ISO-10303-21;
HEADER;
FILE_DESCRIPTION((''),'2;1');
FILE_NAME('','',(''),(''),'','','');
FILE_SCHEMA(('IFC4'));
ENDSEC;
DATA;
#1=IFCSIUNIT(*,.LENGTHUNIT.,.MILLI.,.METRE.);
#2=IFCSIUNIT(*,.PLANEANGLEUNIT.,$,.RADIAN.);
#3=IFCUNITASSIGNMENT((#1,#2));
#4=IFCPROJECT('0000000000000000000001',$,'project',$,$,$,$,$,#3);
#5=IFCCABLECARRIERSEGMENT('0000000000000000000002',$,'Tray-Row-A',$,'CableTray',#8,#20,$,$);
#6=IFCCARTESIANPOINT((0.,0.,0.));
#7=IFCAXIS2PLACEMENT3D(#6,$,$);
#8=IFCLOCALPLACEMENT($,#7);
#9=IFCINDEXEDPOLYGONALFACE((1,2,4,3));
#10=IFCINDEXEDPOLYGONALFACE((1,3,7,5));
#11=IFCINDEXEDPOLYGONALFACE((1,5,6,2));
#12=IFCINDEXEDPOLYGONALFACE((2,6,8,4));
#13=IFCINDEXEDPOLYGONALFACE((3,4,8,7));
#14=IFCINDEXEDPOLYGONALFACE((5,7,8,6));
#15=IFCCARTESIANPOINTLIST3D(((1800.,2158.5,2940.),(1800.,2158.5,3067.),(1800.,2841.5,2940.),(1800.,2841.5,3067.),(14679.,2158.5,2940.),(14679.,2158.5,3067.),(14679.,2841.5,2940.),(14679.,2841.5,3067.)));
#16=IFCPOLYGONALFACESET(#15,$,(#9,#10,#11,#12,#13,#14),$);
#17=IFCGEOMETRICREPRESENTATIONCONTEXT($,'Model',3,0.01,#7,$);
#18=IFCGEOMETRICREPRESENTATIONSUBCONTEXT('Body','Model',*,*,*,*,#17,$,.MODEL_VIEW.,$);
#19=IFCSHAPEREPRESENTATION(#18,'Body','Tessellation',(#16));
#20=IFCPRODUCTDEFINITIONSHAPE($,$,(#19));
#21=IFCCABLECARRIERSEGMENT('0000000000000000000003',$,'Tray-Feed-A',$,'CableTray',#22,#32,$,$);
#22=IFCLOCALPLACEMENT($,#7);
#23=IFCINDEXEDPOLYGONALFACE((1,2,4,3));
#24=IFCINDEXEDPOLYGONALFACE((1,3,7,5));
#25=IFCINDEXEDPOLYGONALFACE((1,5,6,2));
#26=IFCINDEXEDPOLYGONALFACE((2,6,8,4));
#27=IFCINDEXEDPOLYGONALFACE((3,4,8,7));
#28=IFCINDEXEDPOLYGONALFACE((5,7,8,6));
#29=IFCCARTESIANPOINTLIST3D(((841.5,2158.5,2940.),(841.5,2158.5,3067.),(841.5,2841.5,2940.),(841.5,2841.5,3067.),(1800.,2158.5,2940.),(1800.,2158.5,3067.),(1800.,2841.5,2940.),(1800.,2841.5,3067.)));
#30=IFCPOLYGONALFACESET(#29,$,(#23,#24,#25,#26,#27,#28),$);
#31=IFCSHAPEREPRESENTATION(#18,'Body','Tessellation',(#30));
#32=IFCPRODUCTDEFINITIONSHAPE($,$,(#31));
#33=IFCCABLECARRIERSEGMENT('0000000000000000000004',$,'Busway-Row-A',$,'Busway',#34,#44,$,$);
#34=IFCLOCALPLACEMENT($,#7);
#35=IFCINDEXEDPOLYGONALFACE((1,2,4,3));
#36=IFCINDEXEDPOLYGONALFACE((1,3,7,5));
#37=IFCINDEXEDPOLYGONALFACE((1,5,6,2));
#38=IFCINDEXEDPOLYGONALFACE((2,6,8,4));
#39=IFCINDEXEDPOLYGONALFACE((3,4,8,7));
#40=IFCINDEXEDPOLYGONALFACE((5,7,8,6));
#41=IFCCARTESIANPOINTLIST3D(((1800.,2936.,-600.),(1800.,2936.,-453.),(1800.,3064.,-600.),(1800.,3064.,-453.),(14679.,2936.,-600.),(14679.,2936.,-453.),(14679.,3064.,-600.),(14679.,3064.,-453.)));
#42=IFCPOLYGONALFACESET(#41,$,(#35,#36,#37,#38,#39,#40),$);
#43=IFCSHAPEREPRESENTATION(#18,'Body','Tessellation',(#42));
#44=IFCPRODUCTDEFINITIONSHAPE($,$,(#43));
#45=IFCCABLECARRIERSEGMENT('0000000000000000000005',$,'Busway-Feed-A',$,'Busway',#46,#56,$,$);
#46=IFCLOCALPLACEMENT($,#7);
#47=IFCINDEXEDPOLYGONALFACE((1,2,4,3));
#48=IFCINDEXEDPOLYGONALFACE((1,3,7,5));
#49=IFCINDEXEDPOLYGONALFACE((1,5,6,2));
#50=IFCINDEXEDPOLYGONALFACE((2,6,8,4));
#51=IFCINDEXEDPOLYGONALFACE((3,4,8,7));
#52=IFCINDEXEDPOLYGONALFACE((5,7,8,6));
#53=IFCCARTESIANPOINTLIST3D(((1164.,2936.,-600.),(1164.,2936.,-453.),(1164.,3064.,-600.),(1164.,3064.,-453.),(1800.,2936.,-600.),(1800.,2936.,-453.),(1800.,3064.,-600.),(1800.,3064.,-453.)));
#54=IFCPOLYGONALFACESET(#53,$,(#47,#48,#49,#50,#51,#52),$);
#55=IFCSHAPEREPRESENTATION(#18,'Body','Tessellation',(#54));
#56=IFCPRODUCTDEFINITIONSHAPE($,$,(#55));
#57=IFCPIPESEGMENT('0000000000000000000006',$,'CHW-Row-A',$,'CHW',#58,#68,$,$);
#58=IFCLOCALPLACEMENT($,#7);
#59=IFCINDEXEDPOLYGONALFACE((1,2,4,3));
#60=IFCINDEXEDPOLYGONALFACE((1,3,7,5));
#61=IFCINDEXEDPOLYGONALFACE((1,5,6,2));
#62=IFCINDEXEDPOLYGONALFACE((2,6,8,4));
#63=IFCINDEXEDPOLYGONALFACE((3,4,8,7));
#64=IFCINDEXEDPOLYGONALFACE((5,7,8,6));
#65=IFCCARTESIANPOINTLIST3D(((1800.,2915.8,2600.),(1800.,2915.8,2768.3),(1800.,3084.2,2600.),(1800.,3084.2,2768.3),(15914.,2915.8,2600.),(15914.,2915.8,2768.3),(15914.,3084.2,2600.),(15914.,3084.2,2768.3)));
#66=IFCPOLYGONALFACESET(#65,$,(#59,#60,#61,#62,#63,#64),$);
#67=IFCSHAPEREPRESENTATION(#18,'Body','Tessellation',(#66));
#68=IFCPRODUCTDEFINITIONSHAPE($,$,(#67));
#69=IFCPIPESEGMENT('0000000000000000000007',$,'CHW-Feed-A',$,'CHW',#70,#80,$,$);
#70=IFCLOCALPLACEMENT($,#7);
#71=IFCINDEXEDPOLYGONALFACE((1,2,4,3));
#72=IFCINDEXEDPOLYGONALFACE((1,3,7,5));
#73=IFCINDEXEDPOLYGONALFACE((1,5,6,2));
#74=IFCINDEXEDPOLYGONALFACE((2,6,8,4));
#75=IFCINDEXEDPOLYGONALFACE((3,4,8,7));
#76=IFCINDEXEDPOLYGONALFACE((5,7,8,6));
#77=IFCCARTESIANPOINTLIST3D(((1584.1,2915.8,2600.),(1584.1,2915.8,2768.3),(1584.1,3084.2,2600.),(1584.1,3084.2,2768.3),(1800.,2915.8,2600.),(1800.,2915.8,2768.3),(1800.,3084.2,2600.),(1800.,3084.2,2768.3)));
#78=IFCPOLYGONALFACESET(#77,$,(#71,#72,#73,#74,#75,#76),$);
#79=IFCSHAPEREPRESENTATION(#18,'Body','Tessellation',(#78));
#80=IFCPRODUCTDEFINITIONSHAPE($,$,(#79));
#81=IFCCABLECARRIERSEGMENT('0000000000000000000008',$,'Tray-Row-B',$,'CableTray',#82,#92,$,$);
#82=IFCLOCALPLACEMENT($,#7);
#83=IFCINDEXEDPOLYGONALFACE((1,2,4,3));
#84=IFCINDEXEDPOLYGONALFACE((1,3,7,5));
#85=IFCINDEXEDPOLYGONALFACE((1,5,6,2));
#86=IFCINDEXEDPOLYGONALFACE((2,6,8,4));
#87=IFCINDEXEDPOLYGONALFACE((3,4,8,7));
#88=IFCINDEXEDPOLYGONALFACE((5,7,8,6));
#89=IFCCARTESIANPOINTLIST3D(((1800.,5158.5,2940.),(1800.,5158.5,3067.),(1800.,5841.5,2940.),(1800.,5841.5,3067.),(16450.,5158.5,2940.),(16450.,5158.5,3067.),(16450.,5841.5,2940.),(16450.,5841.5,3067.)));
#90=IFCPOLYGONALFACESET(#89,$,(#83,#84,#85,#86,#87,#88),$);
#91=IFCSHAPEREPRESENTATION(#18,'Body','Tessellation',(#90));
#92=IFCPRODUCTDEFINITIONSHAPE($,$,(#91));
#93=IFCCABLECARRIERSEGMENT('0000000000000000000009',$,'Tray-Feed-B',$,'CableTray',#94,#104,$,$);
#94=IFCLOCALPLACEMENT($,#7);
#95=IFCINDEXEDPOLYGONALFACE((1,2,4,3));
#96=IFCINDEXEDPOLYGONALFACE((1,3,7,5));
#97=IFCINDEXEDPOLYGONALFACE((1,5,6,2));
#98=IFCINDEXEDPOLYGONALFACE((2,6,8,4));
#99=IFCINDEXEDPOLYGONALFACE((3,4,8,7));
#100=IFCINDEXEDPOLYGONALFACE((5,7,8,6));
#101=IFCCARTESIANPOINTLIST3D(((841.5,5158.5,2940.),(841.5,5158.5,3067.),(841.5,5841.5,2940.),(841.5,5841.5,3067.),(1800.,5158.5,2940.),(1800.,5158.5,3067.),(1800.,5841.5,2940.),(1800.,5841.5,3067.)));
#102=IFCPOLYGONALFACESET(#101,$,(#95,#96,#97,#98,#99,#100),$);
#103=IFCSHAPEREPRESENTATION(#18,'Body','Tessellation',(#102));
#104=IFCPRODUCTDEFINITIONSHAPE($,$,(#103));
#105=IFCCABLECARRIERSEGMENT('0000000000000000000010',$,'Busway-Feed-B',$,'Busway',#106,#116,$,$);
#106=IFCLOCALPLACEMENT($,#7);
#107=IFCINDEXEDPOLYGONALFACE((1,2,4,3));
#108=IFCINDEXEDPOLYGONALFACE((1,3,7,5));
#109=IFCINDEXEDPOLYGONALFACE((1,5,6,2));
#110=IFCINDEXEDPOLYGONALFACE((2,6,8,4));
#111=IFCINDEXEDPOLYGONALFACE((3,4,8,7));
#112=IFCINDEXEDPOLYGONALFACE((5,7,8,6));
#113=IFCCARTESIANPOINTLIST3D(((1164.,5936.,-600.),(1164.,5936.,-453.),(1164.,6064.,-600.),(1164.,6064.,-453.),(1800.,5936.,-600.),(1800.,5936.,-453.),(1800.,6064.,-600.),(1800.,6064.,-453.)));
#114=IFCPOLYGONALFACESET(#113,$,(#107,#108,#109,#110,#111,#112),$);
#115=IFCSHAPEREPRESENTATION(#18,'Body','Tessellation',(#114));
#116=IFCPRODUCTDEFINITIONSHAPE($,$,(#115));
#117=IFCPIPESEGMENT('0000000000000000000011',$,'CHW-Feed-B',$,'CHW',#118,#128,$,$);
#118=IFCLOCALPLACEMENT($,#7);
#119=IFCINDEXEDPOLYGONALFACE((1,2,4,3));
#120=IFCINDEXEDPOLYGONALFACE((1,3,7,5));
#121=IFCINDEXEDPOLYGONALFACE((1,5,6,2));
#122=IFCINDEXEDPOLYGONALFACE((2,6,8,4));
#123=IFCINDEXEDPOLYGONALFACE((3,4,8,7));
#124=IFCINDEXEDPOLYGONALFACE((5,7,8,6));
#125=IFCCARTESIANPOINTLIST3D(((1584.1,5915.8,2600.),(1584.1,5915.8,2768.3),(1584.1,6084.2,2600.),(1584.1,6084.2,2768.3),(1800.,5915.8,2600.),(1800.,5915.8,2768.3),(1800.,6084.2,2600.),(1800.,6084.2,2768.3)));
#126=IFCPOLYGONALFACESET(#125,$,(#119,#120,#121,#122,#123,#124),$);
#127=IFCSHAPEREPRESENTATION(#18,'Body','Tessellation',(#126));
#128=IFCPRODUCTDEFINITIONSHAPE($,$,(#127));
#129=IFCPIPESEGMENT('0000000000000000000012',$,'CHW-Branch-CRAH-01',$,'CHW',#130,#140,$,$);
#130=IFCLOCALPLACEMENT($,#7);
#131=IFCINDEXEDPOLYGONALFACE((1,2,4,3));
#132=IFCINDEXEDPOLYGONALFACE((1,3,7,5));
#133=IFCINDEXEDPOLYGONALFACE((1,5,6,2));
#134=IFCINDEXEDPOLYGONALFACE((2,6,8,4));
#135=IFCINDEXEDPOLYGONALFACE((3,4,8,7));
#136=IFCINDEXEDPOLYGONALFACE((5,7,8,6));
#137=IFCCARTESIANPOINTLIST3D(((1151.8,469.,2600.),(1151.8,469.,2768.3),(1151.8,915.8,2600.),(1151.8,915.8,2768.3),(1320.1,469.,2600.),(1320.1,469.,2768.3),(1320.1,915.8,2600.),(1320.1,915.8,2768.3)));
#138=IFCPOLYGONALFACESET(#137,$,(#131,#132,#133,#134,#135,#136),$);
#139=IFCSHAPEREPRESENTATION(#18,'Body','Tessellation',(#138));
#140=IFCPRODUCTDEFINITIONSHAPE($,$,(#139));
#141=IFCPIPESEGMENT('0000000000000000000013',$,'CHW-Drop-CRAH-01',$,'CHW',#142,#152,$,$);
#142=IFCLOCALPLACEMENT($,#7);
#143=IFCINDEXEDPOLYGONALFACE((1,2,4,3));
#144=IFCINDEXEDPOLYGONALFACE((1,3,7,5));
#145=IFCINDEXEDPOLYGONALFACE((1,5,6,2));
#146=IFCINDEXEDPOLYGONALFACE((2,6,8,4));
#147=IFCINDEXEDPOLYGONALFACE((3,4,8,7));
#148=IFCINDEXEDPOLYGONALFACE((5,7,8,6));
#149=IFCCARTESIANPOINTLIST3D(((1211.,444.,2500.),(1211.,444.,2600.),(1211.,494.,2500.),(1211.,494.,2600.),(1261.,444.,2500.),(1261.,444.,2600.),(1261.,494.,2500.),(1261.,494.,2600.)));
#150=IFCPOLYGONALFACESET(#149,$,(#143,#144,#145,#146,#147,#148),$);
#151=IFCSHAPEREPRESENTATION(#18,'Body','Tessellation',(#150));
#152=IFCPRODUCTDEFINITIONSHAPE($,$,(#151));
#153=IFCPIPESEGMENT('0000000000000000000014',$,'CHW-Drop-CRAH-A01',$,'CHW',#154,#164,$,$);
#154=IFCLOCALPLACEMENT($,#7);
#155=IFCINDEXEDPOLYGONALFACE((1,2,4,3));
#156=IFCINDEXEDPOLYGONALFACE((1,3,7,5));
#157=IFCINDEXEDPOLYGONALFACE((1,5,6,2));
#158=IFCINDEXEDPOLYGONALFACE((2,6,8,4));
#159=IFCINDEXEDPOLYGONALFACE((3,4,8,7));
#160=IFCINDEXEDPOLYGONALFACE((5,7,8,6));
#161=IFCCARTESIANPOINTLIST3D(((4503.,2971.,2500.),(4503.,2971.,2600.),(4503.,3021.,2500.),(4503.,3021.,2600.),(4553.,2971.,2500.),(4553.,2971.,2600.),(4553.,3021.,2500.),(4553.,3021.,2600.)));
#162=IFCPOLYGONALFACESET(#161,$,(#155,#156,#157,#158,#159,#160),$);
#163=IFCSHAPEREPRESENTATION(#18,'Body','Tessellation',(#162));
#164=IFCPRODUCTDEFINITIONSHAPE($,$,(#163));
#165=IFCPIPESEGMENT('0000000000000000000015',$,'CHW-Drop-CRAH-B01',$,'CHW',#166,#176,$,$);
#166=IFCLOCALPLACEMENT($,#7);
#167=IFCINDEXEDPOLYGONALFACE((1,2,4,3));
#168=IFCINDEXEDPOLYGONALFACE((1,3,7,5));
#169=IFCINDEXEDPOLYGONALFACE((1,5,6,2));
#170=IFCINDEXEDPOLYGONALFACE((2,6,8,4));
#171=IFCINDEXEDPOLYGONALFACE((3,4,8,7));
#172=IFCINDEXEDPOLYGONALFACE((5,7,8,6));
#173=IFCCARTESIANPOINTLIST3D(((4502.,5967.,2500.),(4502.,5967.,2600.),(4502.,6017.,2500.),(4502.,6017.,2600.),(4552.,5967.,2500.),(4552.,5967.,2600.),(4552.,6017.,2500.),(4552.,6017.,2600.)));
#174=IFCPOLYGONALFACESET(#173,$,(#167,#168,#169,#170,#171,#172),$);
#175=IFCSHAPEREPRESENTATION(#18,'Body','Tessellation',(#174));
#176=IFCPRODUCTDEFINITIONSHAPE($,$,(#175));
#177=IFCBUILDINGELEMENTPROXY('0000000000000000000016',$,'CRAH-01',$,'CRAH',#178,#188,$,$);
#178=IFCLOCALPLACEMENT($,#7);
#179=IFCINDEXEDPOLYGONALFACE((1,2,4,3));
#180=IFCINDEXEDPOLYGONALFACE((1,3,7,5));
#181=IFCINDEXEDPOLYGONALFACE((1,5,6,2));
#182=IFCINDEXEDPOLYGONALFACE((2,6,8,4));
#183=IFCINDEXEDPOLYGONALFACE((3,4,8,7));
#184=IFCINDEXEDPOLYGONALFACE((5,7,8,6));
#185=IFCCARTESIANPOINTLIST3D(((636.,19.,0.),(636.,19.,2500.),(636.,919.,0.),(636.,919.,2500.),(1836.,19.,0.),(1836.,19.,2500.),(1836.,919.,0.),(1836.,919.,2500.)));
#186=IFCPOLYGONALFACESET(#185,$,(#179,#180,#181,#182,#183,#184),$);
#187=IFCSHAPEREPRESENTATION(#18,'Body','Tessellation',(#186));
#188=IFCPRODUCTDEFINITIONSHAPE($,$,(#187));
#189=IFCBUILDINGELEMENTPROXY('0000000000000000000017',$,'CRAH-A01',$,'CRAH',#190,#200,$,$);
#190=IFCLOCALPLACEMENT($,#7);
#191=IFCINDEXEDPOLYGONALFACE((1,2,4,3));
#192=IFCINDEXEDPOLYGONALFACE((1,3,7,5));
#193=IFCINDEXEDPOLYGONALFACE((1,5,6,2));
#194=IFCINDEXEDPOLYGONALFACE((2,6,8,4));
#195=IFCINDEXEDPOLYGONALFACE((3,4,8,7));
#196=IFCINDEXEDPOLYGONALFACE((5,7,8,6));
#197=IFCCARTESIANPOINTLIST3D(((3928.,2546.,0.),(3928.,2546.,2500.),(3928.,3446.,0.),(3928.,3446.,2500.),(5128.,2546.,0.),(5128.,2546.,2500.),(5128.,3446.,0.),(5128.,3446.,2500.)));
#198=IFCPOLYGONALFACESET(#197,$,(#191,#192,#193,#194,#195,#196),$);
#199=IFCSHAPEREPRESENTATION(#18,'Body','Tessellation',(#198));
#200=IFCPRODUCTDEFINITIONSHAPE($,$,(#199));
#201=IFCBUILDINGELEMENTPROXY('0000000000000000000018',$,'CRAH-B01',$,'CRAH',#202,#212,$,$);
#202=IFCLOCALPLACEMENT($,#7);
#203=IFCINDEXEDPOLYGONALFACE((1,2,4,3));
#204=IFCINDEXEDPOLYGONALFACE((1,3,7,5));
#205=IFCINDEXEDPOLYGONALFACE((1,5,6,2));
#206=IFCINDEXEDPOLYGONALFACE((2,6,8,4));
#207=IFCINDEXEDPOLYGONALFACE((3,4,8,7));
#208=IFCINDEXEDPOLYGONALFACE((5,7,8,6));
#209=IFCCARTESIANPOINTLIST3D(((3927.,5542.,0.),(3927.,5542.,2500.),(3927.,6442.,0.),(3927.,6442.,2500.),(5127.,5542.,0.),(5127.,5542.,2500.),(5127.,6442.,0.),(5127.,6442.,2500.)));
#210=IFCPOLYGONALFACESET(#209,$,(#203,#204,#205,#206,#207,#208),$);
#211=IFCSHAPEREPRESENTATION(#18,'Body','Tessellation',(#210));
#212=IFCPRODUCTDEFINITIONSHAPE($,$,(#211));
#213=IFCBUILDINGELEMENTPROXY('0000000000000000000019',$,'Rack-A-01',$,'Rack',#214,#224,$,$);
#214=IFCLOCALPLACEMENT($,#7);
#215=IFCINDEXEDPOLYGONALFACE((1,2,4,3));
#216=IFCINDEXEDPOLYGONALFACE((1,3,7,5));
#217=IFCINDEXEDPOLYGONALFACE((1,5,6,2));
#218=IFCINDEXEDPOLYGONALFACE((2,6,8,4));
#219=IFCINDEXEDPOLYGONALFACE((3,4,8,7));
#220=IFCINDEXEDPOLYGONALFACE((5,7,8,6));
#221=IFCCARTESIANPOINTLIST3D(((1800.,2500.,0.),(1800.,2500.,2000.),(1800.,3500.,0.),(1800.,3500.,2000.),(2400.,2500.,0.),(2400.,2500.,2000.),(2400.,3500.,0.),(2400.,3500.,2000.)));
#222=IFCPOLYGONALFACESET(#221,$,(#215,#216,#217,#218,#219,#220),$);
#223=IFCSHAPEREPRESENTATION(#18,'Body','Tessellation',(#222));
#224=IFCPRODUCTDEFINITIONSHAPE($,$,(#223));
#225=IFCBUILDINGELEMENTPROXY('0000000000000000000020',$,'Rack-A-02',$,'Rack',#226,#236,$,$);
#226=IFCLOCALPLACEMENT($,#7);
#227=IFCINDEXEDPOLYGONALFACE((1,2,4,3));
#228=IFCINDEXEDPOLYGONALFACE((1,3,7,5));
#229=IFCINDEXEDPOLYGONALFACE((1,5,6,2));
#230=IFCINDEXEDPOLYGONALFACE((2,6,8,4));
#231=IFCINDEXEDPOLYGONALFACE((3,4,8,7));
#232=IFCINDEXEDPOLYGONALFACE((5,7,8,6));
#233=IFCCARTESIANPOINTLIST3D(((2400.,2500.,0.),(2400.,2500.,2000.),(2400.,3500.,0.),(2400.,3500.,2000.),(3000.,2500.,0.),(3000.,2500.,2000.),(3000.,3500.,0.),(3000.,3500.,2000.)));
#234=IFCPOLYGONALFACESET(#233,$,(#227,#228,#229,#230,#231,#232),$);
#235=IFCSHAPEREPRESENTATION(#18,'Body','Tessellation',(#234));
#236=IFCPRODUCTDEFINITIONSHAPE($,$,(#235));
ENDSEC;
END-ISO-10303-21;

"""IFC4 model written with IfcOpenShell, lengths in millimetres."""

from ifc_helpers import new_model, si_unit, frame, origin, place, context, subcontext, project, rectangle, extrude, element, save


model = new_model("IFC4")

# Units and contexts
model_context = context("Model", 3, precision=0.01, world=origin())
body_context = subcontext(model_context, "Body", "Model", "MODEL_VIEW")
ifc_project = project(units=[si_unit("LENGTHUNIT", "METRE", prefix="MILLI"), si_unit("PLANEANGLEUNIT", "RADIAN")])

# Cable carrier segments
placement = place(None, origin())
cable_carrier_segment_1_placement = place(placement, frame((8239.5, 2500.0, 2940.0)))
element("IfcCableCarrierSegment", 1, at=cable_carrier_segment_1_placement, Name="Tray-Row-A", ObjectType="CableTray", context=body_context, shape_type="SweptSolid", body=[
    extrude(rectangle(XDim=12879.0, YDim=683.0), origin(), (0.0, 0.0, 1.0), 127.0),
])
cable_carrier_segment_2_placement = place(placement, frame((1320.8, 2500.0, 2940.0)))
element("IfcCableCarrierSegment", 2, at=cable_carrier_segment_2_placement, Name="Tray-Feed-A", ObjectType="CableTray", context=body_context, shape_type="SweptSolid", body=[
    extrude(rectangle(XDim=958.5, YDim=683.0), origin(), (0.0, 0.0, 1.0), 127.0),
])
cable_carrier_segment_3_placement = place(placement, frame((8239.5, 3000.0, -600.0)))
element("IfcCableCarrierSegment", 3, at=cable_carrier_segment_3_placement, Name="Busway-Row-A", ObjectType="Busway", context=body_context, shape_type="SweptSolid", body=[
    extrude(rectangle(XDim=12879.0, YDim=128.0), origin(), (0.0, 0.0, 1.0), 147.0),
])
cable_carrier_segment_4_placement = place(placement, frame((1482.0, 3000.0, -600.0)))
element("IfcCableCarrierSegment", 4, at=cable_carrier_segment_4_placement, Name="Busway-Feed-A", ObjectType="Busway", context=body_context, shape_type="SweptSolid", body=[
    extrude(rectangle(XDim=636.0, YDim=128.0), origin(), (0.0, 0.0, 1.0), 147.0),
])

# Pipe segments
pipe_segment_1_placement = place(placement, frame((8857.0, 3000.0, 2600.0)))
element("IfcPipeSegment", 5, at=pipe_segment_1_placement, Name="CHW-Row-A", ObjectType="CHW", context=body_context, shape_type="SweptSolid", body=[
    extrude(rectangle(XDim=14114.0, YDim=168.3), origin(), (0.0, 0.0, 1.0), 168.3),
])
pipe_segment_2_placement = place(placement, frame((1692.1, 3000.0, 2600.0)))
element("IfcPipeSegment", 6, at=pipe_segment_2_placement, Name="CHW-Feed-A", ObjectType="CHW", context=body_context, shape_type="SweptSolid", body=[
    extrude(rectangle(XDim=215.8, YDim=168.3), origin(), (0.0, 0.0, 1.0), 168.3),
])

# Cable carrier segments
cable_carrier_segment_5_placement = place(placement, frame((9125.0, 5500.0, 2940.0)))
element("IfcCableCarrierSegment", 7, at=cable_carrier_segment_5_placement, Name="Tray-Row-B", ObjectType="CableTray", context=body_context, shape_type="SweptSolid", body=[
    extrude(rectangle(XDim=14650.0, YDim=683.0), origin(), (0.0, 0.0, 1.0), 127.0),
])
cable_carrier_segment_6_placement = place(placement, frame((1320.8, 5500.0, 2940.0)))
element("IfcCableCarrierSegment", 8, at=cable_carrier_segment_6_placement, Name="Tray-Feed-B", ObjectType="CableTray", context=body_context, shape_type="SweptSolid", body=[
    extrude(rectangle(XDim=958.5, YDim=683.0), origin(), (0.0, 0.0, 1.0), 127.0),
])
cable_carrier_segment_7_placement = place(placement, frame((1482.0, 6000.0, -600.0)))
element("IfcCableCarrierSegment", 9, at=cable_carrier_segment_7_placement, Name="Busway-Feed-B", ObjectType="Busway", context=body_context, shape_type="SweptSolid", body=[
    extrude(rectangle(XDim=636.0, YDim=128.0), origin(), (0.0, 0.0, 1.0), 147.0),
])

# Pipe segments
pipe_segment_3_placement = place(placement, frame((1692.1, 6000.0, 2600.0)))
element("IfcPipeSegment", 10, at=pipe_segment_3_placement, Name="CHW-Feed-B", ObjectType="CHW", context=body_context, shape_type="SweptSolid", body=[
    extrude(rectangle(XDim=215.8, YDim=168.3), origin(), (0.0, 0.0, 1.0), 168.3),
])
pipe_segment_4_placement = place(placement, frame((1236.0, 692.4, 2600.0)))
element("IfcPipeSegment", 11, at=pipe_segment_4_placement, Name="CHW-Branch-CRAH-01", ObjectType="CHW", context=body_context, shape_type="SweptSolid", body=[
    extrude(rectangle(XDim=168.3, YDim=446.9), origin(), (0.0, 0.0, 1.0), 168.3),
])
for number, where, name in (
    (12, (1236.0, 469.0, 2500.0), "CHW-Drop-CRAH-01"),
    (13, (4528.0, 2996.0, 2500.0), "CHW-Drop-CRAH-A01"),
    (14, (4527.0, 5992.0, 2500.0), "CHW-Drop-CRAH-B01"),
):
    element("IfcPipeSegment", number, at=place(placement, frame(where)), Name=name, ObjectType="CHW", context=body_context, shape_type="SweptSolid", body=[
        extrude(rectangle(XDim=50.0, YDim=50.0), origin(), (0.0, 0.0, 1.0), 100.0),
    ])

# Building element proxies
for number, where, name in (
    (15, (1236.0, 469.0, 0.0), "CRAH-01"),
    (16, (4528.0, 2996.0, 0.0), "CRAH-A01"),
    (17, (4527.0, 5992.0, 0.0), "CRAH-B01"),
):
    element("IfcBuildingElementProxy", number, at=place(placement, frame(where)), Name=name, ObjectType="CRAH", context=body_context, shape_type="SweptSolid", body=[
        extrude(rectangle(XDim=1200.0, YDim=900.0), origin(), (0.0, 0.0, 1.0), 2500.0),
    ])
for number, where, name in (
    (18, (2100.0, 3000.0, 0.0), "Rack-A-01"),
    (19, (2700.0, 3000.0, 0.0), "Rack-A-02"),
):
    element("IfcBuildingElementProxy", number, at=place(placement, frame(where)), Name=name, ObjectType="Rack", context=body_context, shape_type="SweptSolid", body=[
        extrude(rectangle(XDim=600.0, YDim=1000.0), origin(), (0.0, 0.0, 1.0), 2000.0),
    ])

save(model, "model.ifc")
